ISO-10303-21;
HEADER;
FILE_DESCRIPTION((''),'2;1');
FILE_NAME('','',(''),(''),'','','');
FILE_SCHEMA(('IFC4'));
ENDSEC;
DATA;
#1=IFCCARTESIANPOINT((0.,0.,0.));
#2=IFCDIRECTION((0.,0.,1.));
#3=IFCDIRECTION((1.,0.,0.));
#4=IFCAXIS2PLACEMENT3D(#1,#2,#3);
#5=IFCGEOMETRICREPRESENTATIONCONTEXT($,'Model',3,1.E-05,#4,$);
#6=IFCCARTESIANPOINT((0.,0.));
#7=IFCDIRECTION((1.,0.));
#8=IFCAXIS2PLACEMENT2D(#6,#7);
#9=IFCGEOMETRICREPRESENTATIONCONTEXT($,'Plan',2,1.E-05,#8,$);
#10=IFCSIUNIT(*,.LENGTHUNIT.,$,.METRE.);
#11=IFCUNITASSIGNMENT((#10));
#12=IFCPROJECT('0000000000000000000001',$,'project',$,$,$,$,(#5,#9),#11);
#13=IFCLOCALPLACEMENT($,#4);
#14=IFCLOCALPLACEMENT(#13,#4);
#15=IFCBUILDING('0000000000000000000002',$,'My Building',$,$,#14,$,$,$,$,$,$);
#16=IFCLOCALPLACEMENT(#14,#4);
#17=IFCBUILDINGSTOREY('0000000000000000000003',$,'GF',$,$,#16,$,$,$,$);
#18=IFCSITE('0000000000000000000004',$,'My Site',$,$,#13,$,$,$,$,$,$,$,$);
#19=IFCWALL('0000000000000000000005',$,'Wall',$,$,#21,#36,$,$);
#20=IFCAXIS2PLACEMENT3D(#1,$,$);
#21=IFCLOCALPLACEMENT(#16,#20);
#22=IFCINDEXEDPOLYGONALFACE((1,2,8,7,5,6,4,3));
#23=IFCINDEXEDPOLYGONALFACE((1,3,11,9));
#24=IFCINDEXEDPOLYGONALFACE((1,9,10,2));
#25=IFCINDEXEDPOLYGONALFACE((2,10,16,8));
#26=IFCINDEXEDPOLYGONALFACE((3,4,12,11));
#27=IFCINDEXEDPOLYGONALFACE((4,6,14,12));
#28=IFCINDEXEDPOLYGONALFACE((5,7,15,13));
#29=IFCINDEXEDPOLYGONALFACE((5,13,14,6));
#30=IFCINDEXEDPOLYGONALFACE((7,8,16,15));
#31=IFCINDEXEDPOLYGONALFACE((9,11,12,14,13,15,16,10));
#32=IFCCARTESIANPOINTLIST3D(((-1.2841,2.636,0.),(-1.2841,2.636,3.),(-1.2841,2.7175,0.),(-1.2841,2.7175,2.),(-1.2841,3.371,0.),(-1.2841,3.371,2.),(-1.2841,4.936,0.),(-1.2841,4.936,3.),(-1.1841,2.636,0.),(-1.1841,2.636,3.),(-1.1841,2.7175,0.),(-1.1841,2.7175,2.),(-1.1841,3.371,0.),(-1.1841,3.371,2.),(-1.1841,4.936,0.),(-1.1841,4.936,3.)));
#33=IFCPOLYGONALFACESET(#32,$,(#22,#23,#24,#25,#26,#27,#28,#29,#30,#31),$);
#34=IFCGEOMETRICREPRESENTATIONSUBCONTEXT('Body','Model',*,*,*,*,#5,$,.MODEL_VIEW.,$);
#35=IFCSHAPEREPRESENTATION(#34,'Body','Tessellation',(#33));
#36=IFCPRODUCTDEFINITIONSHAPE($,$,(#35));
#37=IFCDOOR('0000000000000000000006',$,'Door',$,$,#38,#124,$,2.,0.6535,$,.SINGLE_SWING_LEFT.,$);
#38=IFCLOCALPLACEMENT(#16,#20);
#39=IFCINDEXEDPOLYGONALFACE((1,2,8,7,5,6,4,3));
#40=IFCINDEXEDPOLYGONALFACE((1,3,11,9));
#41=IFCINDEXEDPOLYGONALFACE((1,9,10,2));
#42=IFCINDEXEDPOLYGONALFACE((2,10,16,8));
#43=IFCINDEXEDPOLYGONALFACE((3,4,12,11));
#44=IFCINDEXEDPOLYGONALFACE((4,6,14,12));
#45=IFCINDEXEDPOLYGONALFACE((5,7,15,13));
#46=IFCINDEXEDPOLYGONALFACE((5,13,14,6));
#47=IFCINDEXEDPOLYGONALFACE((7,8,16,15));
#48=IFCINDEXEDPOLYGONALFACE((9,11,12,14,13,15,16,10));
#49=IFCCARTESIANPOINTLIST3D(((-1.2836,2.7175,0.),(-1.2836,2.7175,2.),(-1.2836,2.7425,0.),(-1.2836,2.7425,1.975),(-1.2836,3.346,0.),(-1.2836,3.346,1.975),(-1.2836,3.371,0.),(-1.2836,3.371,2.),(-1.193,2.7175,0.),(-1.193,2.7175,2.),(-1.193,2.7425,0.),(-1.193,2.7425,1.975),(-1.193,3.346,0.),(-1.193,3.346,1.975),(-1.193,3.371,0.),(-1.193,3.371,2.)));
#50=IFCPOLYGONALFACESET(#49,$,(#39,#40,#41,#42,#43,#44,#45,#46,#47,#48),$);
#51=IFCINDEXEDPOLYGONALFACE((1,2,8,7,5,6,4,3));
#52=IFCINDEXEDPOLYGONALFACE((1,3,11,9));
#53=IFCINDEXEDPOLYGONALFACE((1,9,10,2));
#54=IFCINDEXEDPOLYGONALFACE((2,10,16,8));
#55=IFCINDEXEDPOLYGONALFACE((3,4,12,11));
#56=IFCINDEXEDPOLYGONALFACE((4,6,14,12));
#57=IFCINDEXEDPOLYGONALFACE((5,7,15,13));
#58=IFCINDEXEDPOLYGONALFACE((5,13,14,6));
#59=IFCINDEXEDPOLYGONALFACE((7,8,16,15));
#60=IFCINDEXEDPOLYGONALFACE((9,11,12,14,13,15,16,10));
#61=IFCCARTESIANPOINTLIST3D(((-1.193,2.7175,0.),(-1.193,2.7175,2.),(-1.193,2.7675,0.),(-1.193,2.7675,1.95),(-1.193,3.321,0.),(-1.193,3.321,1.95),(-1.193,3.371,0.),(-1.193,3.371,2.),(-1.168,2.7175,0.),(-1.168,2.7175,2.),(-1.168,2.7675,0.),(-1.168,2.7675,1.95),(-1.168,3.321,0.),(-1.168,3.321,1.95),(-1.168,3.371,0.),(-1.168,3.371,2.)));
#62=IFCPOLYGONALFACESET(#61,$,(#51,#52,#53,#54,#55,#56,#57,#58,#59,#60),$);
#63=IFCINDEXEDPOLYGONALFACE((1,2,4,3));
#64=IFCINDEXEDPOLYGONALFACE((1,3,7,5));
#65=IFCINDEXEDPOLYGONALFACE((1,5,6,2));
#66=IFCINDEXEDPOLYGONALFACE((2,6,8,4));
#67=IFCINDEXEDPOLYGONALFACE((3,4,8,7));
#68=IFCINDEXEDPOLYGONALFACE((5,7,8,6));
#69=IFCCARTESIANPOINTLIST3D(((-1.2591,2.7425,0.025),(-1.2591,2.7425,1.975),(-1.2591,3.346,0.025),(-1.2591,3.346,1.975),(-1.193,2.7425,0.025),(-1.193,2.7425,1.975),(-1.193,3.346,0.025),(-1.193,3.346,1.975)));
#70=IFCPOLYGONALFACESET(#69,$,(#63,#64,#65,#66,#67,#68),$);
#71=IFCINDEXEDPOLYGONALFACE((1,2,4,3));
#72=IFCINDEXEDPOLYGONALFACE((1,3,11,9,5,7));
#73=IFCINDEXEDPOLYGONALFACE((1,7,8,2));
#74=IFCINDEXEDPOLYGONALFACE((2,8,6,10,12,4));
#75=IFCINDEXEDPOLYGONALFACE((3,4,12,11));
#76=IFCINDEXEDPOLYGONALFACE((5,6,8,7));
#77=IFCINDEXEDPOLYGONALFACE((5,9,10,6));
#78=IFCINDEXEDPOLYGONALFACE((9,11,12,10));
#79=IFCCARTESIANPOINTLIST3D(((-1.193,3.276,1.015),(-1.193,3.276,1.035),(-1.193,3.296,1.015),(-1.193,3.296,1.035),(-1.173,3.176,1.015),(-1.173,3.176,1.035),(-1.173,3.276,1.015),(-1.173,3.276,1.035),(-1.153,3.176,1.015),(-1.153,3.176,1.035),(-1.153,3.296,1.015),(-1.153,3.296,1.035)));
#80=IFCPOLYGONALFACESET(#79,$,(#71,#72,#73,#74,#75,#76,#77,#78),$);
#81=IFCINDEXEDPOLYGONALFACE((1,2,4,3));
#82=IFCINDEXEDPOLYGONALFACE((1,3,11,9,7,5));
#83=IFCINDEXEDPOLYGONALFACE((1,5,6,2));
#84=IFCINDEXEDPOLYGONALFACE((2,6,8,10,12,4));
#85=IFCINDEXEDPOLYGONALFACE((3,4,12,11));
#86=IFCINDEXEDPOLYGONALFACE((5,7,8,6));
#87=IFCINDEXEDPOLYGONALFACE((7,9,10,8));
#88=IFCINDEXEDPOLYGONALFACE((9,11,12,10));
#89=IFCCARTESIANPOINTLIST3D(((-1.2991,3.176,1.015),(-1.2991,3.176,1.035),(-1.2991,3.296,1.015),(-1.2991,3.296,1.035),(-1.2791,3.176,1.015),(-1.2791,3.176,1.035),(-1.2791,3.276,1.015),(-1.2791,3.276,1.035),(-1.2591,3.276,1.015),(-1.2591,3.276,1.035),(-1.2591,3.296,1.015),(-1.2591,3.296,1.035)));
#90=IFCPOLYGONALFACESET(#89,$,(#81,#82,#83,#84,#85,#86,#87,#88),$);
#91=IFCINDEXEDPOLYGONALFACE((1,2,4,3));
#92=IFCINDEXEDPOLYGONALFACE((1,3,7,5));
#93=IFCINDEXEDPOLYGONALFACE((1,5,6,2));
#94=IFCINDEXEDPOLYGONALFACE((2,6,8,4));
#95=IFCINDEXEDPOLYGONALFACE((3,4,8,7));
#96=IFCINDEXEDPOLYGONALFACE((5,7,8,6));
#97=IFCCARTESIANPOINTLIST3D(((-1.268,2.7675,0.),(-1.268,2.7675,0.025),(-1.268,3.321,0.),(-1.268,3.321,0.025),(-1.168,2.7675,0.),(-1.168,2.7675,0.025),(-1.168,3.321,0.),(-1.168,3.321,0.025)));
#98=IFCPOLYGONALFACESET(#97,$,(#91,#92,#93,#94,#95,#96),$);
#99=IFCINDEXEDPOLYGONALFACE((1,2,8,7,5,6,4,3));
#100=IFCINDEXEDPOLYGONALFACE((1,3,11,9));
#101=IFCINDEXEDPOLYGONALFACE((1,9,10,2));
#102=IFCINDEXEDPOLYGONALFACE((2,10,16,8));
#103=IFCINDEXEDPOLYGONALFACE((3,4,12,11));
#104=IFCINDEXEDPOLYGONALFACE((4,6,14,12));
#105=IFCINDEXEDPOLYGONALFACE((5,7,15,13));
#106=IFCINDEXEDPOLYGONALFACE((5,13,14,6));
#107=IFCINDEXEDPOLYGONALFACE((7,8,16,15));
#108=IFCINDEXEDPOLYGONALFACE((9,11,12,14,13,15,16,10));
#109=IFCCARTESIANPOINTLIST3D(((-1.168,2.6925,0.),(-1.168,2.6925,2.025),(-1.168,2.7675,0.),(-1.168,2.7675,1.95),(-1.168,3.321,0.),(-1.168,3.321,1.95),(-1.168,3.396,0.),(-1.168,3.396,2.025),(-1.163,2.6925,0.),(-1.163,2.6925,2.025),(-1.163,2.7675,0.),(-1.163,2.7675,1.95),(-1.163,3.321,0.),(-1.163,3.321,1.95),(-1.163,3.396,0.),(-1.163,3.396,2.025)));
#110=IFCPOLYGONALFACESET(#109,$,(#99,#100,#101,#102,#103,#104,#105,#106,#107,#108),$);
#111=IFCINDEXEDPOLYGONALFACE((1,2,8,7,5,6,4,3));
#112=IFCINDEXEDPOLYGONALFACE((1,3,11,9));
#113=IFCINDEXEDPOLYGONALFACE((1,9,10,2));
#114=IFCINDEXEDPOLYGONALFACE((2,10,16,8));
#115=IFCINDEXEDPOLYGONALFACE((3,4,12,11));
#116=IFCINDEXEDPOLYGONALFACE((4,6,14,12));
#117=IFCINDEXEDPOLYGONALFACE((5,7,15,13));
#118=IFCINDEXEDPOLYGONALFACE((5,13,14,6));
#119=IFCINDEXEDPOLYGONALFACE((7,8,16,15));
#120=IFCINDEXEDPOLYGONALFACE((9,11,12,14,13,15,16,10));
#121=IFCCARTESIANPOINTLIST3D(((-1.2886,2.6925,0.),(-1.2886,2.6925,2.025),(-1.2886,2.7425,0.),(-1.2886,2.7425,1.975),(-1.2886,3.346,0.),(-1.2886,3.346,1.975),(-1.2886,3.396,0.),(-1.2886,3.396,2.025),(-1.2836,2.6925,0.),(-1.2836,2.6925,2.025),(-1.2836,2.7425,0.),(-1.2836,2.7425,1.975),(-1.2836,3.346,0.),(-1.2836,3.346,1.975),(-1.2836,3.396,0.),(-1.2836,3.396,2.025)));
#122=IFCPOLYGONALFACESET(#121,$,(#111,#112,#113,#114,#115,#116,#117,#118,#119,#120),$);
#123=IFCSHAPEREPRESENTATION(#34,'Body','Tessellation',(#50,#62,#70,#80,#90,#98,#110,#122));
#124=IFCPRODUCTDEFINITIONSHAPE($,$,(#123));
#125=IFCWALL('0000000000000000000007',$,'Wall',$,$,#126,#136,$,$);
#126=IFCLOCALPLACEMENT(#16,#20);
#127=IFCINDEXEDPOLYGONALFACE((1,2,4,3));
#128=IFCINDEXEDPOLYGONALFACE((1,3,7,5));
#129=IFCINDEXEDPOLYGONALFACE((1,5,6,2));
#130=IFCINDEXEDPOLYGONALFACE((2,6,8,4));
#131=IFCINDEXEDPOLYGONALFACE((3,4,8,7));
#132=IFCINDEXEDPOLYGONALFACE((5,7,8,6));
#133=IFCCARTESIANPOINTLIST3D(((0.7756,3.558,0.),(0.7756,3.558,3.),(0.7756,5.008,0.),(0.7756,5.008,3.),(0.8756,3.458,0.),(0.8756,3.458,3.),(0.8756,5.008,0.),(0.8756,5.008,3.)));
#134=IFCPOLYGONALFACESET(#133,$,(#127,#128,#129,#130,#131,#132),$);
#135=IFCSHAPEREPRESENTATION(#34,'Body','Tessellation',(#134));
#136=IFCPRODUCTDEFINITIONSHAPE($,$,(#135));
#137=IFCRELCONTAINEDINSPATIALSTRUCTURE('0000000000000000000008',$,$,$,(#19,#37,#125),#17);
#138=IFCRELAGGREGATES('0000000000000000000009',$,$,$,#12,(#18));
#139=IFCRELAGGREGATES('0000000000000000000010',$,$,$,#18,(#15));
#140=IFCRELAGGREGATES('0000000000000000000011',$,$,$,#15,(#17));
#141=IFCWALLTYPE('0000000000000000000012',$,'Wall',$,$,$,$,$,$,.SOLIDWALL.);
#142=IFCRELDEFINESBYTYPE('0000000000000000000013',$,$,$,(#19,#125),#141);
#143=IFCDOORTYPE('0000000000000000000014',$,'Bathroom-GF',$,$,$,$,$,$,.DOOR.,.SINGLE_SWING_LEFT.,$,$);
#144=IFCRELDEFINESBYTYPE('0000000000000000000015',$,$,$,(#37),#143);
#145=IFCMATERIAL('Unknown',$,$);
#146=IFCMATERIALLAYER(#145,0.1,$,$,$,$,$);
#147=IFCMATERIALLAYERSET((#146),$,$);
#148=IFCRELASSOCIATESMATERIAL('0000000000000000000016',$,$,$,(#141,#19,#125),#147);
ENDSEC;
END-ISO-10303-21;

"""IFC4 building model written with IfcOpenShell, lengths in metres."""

from ifc_helpers import new_model, entity, si_unit, frame, origin_with_axes, origin_2d_with_axis, place, context, subcontext, project, spatial, line, indexed_curve, outline, extrude, shape, source, transform, mapped, material, layer, layer_set, layer_usage, type_object, type_shapes, element, fill, save


model = new_model("IFC4")

# Units and contexts
model_context = context("Model", 3, precision=1e-05, world=origin_with_axes())
plan_context = context("Plan", 2, precision=1e-05, world=origin_2d_with_axis())
body_context_1 = subcontext(model_context, "Body", "Model", "MODEL_VIEW")
body_context_2 = subcontext(plan_context, "Body", "Plan", "PLAN_VIEW")
ifc_project = project(units=[si_unit("LENGTHUNIT", "METRE")], contexts=[model_context, plan_context])

# Site, building, storey
site_placement = place(None, origin_with_axes())
site = spatial("IfcSite", under=ifc_project, at=site_placement, Name="My Site")
building_placement = place(site_placement, origin_with_axes())
building = spatial("IfcBuilding", under=site, at=building_placement, Name="My Building")
storey_placement = place(building_placement, origin_with_axes())
storey = spatial("IfcBuildingStorey", under=building, at=storey_placement, Name="GF")

# Shared definitions
ifc_material_1 = material(Name="Unknown")

# Shared definitions
ifc_layer_1 = layer(ifc_material_1, 0.1)
ifc_layer_set_1 = layer_set([ifc_layer_1])
wall_type = type_object("IfcWallType", Name="Wall", PredefinedType="SOLIDWALL", material=ifc_layer_set_1)

# Wall, opening, door
ifc_layer_usage_1 = layer_usage(ifc_layer_set_1, "AXIS2", "POSITIVE", 0.0)
wall_1_placement = place(storey_placement, frame((-1.1841, 2.636, 0.0), z_axis=(0.0, 0.0, 1.0), x_axis=(0.0, 1.0, 0.0)))
wall_1 = element("IfcWall", 1, at=wall_1_placement, inside=storey, type_object=wall_type, material=ifc_layer_usage_1, Name="Wall", context=body_context_1, shape_type="SweptSolid", body=[
    extrude(outline(indexed_curve([(0.0, 0.0), (0.0, 0.1), (2.3, 0.1), (2.3, 0.0)], segments=[line(1, 2, 3, 4, 1)])), origin_with_axes(), (0.0, 0.0, 1.0), 3.0),
])
shared_shape_1 = source(origin_with_axes(), body_context_1, "Body", "SweptSolid", [
    extrude(outline(indexed_curve([(0.0, 0.0), (0.6535, 0.0), (0.6535, 2.0), (0.0, 2.0)], segments=[line(1, 2, 3, 4, 1)])), frame((0.0, -0.6, 0.0), z_axis=(0.0, -1.0, 0.0), x_axis=(1.0, 0.0, 0.0)), (0.0, 0.0, -1.0), 1.2),
])
opening_1_placement = place(wall_1_placement, frame((0.0815, -0.0161, 0.0), z_axis=(0.0, 0.0, 1.0), x_axis=(1.0, 0.0, 0.0)))
opening_1 = element("IfcOpeningElement", 2, at=opening_1_placement, cuts=wall_1, PredefinedType="OPENING", context=body_context_1, shape_type="MappedRepresentation", body=[
    mapped(shared_shape_1, transform((0.0, 0.0, 0.0), x_axis=(1.0, 0.0, 0.0), y_axis=(0.0, 1.0, 0.0), z_axis=(0.0, 0.0, 1.0), scale=1.0)),
])
door_type_1 = type_object("IfcDoorType", Name="Bathroom-GF", OperationType="SINGLE_SWING_LEFT", PredefinedType="DOOR")
shared_shape_2 = source(origin_with_axes(), body_context_1, "Body", "SweptSolid", [
    extrude(outline(indexed_curve([(0.0, 0.0), (0.0, 2.0), (0.6535, 2.0), (0.6535, 0.0), (0.6285, 0.0), (0.6285, 1.975), (0.025, 1.975), (0.025, 0.0)], segments=[line(1, 2, 3, 4, 5, 6, 7, 8, 1)])), frame((0.0, 0.025, 0.0), z_axis=(0.0, -1.0, 0.0), x_axis=(1.0, 0.0, 0.0)), (0.0, 0.0, -1.0), 0.0906),
    extrude(outline(indexed_curve([(0.0, 0.0), (0.0, 2.0), (0.6535, 2.0), (0.6535, 0.0), (0.6035, 0.0), (0.6035, 1.95), (0.05, 1.95), (0.05, 0.0)], segments=[line(1, 2, 3, 4, 5, 6, 7, 8, 1)])), frame((0.0, 0.0, 0.0), z_axis=(0.0, -1.0, 0.0), x_axis=(1.0, 0.0, 0.0)), (0.0, 0.0, -1.0), 0.025),
    extrude(outline(indexed_curve([(0.0, 0.0), (0.6035, 0.0), (0.6035, 0.0661), (0.0, 0.0661)], segments=[line(1, 2, 3, 4, 1)])), frame((0.025, 0.025, 0.025), z_axis=(0.0, 0.0, 1.0), x_axis=(1.0, 0.0, 0.0)), (0.0, 0.0, 1.0), 1.95),
    extrude(outline(indexed_curve([(0.0, 0.0), (0.0, -0.04), (-0.12, -0.04), (-0.12, -0.02), (-0.02, -0.02), (-0.02, 0.0)], segments=[line(1, 2, 3, 4, 5, 6, 1)])), frame((0.5785, 0.025, 1.015), z_axis=(0.0, 0.0, 1.0), x_axis=(1.0, 0.0, 0.0)), (0.0, 0.0, 1.0), 0.02),
    extrude(outline(indexed_curve([(0.0, 0.0), (0.0, 0.04), (-0.12, 0.04), (-0.12, 0.02), (-0.02, 0.02), (-0.02, 0.0)], segments=[line(1, 2, 3, 4, 5, 6, 1)])), frame((0.5785, 0.0911, 1.015), z_axis=(0.0, 0.0, 1.0), x_axis=(1.0, 0.0, 0.0)), (0.0, 0.0, 1.0), 0.02),
    extrude(outline(indexed_curve([(0.0, 0.0), (0.5535, 0.0), (0.5535, 0.1), (0.0, 0.1)], segments=[line(1, 2, 3, 4, 1)])), frame((0.05, 0.0, 0.0), z_axis=(0.0, 0.0, 1.0), x_axis=(1.0, 0.0, 0.0)), (0.0, 0.0, 1.0), 0.025),
    extrude(outline(indexed_curve([(0.0, 0.0), (0.0, 2.025), (0.7035, 2.025), (0.7035, 0.0), (0.6285, 0.0), (0.6285, 1.95), (0.075, 1.95), (0.075, 0.0)], segments=[line(1, 2, 3, 4, 5, 6, 7, 8, 1)])), frame((-0.025, -0.005, 0.0), z_axis=(0.0, -1.0, 0.0), x_axis=(1.0, 0.0, 0.0)), (0.0, 0.0, -1.0), 0.005),
    extrude(outline(indexed_curve([(0.0, 0.0), (0.0, 2.025), (0.7035, 2.025), (0.7035, 0.0), (0.6535, 0.0), (0.6535, 1.975), (0.05, 1.975), (0.05, 0.0)], segments=[line(1, 2, 3, 4, 5, 6, 7, 8, 1)])), frame((-0.025, 0.1156, 0.0), z_axis=(0.0, -1.0, 0.0), x_axis=(1.0, 0.0, 0.0)), (0.0, 0.0, -1.0), 0.005),
])
shared_shape_3 = source(origin_with_axes(), body_context_2, "Body", "Curve2D", [
    entity("IfcIndexedPolyCurve", entity("IfcCartesianPointList2D", [[0.0, 0.0], [0.0, 0.1156], [0.025, 0.1156], [0.025, 0.025], [0.05, 0.025], [0.05, 0.0]]), [entity("IfcLineIndex", [1, 2, 3, 4, 5, 6, 1])]),
    entity("IfcIndexedPolyCurve", entity("IfcCartesianPointList2D", [[0.6535, 0.0], [0.6535, 0.1156], [0.6285, 0.1156], [0.6285, 0.025], [0.6035, 0.025], [0.6035, 0.0]]), [entity("IfcLineIndex", [1, 2, 3, 4, 5, 6, 1])]),
    entity("IfcTrimmedCurve", entity("IfcEllipse", entity("IfcAxis2Placement2D", entity("IfcCartesianPoint", [0.0911, 0.1156]), entity("IfcDirection", [1.0, 0.0])), 0.5374, 0.6035), [entity("IfcCartesianPoint", [0.6285, 0.1156])], [entity("IfcCartesianPoint", [0.0911, 0.7191])], True, "CARTESIAN"),
    entity("IfcIndexedPolyCurve", entity("IfcCartesianPointList2D", [[0.025, 0.1156], [0.0911, 0.1156], [0.0911, 0.7191], [0.025, 0.7191]]), [entity("IfcLineIndex", [1, 2, 3, 4, 1])]),
])
type_shapes(door_type_1, [shared_shape_2, shared_shape_3])
door_1_placement = place(opening_1_placement, origin_with_axes())
door_1 = element("IfcDoor", 3, at=door_1_placement, inside=storey, type_object=door_type_1, Name="Door", OperationType="SINGLE_SWING_LEFT", OverallHeight=2.0, OverallWidth=0.6535, shapes=[
    shape(body_context_1, "Body", "MappedRepresentation", [mapped(shared_shape_2, transform((0.0, 0.0, 0.0), x_axis=(1.0, 0.0, 0.0), y_axis=(0.0, 1.0, 0.0), z_axis=(0.0, 0.0, 1.0), scale=1.0))]),
    shape(body_context_2, "Body", "MappedRepresentation", [mapped(shared_shape_3, transform((0.0, 0.0, 0.0), x_axis=(1.0, 0.0, 0.0), y_axis=(0.0, 1.0, 0.0), z_axis=(0.0, 0.0, 1.0), scale=1.0))]),
])
fill(opening_1, door_1)

# Wall
ifc_layer_usage_2 = layer_usage(ifc_layer_set_1, "AXIS2", "POSITIVE", 0.0)
wall_2_placement = place(storey_placement, frame((0.7756, 5.008, 0.0), z_axis=(0.0, 0.0, 1.0), x_axis=(0.0, -1.0, 0.0)))
element("IfcWall", 4, at=wall_2_placement, inside=storey, type_object=wall_type, material=ifc_layer_usage_2, Name="Wall", context=body_context_1, shape_type="SweptSolid", body=[
    extrude(outline(indexed_curve([(0.0, 0.0), (0.0, 0.1), (1.55, 0.1), (1.45, 0.0)], segments=[line(1, 2, 3, 4, 1)])), origin_with_axes(), (0.0, 0.0, 1.0), 3.0),
])

save(model, "model.ifc")
